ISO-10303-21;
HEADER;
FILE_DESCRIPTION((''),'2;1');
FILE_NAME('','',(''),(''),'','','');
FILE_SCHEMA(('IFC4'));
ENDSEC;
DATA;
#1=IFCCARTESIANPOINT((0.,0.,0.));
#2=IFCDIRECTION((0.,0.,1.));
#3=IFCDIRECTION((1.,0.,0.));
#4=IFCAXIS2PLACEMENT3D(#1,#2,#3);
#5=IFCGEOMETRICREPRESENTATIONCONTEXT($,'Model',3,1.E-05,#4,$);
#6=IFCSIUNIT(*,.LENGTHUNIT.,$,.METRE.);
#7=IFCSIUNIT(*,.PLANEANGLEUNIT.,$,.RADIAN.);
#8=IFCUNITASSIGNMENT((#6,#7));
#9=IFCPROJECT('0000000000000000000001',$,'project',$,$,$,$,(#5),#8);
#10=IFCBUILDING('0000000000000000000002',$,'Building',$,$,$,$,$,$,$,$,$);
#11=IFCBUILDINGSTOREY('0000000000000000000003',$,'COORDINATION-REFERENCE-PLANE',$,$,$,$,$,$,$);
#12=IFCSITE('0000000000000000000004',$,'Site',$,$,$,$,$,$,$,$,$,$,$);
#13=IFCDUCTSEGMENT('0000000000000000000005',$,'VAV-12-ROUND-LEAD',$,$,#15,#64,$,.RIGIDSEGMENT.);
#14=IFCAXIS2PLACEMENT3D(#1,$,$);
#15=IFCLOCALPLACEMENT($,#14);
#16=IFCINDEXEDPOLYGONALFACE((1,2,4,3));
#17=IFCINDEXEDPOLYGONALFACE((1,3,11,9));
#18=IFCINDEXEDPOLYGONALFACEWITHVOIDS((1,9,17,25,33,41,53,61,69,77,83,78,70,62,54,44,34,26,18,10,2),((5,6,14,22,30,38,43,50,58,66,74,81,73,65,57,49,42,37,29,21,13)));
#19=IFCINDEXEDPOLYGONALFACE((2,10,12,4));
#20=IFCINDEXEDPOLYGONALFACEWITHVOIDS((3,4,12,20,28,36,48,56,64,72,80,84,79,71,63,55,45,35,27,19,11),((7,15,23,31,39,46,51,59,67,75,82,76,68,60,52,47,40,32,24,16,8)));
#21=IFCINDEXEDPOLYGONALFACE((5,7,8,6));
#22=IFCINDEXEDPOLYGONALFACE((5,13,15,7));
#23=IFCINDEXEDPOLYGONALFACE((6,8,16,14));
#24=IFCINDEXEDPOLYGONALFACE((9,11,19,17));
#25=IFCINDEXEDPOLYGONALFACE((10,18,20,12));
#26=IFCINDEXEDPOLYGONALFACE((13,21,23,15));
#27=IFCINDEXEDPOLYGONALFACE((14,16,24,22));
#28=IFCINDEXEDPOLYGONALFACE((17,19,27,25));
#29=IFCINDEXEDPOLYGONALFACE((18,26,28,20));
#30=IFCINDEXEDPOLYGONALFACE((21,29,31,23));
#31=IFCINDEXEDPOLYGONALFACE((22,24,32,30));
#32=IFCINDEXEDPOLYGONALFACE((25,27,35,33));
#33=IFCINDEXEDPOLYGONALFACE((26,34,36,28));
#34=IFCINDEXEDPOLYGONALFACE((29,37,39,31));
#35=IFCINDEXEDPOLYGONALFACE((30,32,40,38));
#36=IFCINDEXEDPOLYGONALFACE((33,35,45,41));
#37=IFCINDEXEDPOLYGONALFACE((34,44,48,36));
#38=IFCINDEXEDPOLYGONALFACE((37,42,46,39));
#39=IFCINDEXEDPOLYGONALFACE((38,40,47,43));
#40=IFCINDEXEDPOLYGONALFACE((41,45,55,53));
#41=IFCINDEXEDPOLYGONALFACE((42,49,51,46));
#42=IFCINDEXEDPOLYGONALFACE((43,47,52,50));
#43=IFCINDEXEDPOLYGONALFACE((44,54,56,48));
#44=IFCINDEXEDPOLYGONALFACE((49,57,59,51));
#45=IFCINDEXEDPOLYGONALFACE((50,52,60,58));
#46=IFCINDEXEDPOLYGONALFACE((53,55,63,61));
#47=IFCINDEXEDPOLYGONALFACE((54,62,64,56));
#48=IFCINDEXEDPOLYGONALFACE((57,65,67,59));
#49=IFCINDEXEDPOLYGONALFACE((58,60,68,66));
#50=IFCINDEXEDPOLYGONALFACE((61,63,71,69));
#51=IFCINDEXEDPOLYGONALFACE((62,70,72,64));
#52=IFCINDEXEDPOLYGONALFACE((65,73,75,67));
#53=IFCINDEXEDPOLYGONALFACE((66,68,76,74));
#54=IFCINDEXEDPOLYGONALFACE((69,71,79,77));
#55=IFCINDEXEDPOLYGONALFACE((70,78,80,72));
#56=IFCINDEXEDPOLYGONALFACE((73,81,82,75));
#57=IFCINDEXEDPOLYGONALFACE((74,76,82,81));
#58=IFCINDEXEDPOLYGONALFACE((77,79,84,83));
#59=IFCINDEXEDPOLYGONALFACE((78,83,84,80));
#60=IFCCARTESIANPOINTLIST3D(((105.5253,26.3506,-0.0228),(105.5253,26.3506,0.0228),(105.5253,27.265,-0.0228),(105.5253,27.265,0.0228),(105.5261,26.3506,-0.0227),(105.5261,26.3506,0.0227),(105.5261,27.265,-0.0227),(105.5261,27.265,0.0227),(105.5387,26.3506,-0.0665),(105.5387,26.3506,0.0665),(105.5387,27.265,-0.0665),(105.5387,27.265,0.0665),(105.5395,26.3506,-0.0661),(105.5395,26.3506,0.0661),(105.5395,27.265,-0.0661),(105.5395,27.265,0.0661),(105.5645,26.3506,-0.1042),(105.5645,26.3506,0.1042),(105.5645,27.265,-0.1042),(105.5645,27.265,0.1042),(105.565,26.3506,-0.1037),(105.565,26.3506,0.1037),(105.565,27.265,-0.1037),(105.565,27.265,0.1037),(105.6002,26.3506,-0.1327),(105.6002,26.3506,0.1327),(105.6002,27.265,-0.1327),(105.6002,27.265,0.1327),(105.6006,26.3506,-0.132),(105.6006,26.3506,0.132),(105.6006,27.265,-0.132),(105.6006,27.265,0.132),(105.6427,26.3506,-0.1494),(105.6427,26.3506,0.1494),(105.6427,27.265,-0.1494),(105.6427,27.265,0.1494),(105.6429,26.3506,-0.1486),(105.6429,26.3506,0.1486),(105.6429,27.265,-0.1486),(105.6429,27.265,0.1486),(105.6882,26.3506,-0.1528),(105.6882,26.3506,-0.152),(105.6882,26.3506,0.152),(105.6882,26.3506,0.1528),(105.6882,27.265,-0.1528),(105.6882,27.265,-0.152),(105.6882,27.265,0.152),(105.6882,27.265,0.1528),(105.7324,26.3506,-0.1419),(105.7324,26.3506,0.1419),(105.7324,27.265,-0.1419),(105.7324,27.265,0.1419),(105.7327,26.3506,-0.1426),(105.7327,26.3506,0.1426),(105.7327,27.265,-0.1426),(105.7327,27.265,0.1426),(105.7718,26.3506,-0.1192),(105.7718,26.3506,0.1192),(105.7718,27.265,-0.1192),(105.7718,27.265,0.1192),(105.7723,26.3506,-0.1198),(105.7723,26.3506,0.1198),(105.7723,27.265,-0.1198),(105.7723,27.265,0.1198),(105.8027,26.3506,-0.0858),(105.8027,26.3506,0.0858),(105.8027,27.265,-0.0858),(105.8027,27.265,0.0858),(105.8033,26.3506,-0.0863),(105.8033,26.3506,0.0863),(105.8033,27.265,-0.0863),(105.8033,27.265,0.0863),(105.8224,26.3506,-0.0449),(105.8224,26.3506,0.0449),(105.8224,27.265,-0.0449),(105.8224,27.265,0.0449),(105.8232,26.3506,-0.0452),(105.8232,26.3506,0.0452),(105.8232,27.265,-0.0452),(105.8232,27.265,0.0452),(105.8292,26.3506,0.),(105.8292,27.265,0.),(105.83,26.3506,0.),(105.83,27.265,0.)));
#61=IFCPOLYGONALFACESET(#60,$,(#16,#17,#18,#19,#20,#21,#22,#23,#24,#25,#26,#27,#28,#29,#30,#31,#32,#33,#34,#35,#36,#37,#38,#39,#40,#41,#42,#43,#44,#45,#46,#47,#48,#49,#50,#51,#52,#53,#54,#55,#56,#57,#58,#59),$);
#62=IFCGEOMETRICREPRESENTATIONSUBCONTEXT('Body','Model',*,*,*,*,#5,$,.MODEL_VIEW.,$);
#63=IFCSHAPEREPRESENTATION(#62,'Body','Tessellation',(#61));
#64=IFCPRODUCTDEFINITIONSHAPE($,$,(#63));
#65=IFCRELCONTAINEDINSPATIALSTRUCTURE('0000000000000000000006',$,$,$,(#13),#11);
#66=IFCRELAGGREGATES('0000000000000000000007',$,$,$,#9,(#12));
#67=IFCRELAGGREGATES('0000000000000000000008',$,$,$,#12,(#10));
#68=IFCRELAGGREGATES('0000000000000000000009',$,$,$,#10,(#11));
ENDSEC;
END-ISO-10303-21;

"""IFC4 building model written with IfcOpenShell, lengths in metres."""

from ifc_helpers import new_model, si_unit, frame, origin, origin_with_axes, place, context, subcontext, project, spatial, hollow_circle, extrude, element, save


model = new_model("IFC4")

# Units and contexts
model_context = context("Model", 3, precision=1e-05, world=origin_with_axes())
body_context_1 = subcontext(model_context, "Body", "Model", "MODEL_VIEW")
ifc_project = project(units=[si_unit("LENGTHUNIT", "METRE"), si_unit("PLANEANGLEUNIT", "RADIAN")], contexts=[model_context])

# Site, building, storey
site = spatial("IfcSite", under=ifc_project, Name="Site")
building = spatial("IfcBuilding", under=site, Name="Building")
storey = spatial("IfcBuildingStorey", under=building, Name="COORDINATION-REFERENCE-PLANE")

# Duct segment
duct_segment_1_placement = place(None, frame((105.6768, 27.265, 0.0), z_axis=(0.0, -1.0, 0.0), x_axis=(1.0, 0.0, 0.0)))
element("IfcDuctSegment", 1, at=duct_segment_1_placement, inside=storey, Name="VAV-12-ROUND-LEAD", PredefinedType="RIGIDSEGMENT", context=body_context_1, shape_type="SweptSolid", body=[
    extrude(hollow_circle(Radius=0.1532, WallThickness=0.0008), origin(), (0.0, 0.0, 1.0), 0.9144),
])

save(model, "model.ifc")
